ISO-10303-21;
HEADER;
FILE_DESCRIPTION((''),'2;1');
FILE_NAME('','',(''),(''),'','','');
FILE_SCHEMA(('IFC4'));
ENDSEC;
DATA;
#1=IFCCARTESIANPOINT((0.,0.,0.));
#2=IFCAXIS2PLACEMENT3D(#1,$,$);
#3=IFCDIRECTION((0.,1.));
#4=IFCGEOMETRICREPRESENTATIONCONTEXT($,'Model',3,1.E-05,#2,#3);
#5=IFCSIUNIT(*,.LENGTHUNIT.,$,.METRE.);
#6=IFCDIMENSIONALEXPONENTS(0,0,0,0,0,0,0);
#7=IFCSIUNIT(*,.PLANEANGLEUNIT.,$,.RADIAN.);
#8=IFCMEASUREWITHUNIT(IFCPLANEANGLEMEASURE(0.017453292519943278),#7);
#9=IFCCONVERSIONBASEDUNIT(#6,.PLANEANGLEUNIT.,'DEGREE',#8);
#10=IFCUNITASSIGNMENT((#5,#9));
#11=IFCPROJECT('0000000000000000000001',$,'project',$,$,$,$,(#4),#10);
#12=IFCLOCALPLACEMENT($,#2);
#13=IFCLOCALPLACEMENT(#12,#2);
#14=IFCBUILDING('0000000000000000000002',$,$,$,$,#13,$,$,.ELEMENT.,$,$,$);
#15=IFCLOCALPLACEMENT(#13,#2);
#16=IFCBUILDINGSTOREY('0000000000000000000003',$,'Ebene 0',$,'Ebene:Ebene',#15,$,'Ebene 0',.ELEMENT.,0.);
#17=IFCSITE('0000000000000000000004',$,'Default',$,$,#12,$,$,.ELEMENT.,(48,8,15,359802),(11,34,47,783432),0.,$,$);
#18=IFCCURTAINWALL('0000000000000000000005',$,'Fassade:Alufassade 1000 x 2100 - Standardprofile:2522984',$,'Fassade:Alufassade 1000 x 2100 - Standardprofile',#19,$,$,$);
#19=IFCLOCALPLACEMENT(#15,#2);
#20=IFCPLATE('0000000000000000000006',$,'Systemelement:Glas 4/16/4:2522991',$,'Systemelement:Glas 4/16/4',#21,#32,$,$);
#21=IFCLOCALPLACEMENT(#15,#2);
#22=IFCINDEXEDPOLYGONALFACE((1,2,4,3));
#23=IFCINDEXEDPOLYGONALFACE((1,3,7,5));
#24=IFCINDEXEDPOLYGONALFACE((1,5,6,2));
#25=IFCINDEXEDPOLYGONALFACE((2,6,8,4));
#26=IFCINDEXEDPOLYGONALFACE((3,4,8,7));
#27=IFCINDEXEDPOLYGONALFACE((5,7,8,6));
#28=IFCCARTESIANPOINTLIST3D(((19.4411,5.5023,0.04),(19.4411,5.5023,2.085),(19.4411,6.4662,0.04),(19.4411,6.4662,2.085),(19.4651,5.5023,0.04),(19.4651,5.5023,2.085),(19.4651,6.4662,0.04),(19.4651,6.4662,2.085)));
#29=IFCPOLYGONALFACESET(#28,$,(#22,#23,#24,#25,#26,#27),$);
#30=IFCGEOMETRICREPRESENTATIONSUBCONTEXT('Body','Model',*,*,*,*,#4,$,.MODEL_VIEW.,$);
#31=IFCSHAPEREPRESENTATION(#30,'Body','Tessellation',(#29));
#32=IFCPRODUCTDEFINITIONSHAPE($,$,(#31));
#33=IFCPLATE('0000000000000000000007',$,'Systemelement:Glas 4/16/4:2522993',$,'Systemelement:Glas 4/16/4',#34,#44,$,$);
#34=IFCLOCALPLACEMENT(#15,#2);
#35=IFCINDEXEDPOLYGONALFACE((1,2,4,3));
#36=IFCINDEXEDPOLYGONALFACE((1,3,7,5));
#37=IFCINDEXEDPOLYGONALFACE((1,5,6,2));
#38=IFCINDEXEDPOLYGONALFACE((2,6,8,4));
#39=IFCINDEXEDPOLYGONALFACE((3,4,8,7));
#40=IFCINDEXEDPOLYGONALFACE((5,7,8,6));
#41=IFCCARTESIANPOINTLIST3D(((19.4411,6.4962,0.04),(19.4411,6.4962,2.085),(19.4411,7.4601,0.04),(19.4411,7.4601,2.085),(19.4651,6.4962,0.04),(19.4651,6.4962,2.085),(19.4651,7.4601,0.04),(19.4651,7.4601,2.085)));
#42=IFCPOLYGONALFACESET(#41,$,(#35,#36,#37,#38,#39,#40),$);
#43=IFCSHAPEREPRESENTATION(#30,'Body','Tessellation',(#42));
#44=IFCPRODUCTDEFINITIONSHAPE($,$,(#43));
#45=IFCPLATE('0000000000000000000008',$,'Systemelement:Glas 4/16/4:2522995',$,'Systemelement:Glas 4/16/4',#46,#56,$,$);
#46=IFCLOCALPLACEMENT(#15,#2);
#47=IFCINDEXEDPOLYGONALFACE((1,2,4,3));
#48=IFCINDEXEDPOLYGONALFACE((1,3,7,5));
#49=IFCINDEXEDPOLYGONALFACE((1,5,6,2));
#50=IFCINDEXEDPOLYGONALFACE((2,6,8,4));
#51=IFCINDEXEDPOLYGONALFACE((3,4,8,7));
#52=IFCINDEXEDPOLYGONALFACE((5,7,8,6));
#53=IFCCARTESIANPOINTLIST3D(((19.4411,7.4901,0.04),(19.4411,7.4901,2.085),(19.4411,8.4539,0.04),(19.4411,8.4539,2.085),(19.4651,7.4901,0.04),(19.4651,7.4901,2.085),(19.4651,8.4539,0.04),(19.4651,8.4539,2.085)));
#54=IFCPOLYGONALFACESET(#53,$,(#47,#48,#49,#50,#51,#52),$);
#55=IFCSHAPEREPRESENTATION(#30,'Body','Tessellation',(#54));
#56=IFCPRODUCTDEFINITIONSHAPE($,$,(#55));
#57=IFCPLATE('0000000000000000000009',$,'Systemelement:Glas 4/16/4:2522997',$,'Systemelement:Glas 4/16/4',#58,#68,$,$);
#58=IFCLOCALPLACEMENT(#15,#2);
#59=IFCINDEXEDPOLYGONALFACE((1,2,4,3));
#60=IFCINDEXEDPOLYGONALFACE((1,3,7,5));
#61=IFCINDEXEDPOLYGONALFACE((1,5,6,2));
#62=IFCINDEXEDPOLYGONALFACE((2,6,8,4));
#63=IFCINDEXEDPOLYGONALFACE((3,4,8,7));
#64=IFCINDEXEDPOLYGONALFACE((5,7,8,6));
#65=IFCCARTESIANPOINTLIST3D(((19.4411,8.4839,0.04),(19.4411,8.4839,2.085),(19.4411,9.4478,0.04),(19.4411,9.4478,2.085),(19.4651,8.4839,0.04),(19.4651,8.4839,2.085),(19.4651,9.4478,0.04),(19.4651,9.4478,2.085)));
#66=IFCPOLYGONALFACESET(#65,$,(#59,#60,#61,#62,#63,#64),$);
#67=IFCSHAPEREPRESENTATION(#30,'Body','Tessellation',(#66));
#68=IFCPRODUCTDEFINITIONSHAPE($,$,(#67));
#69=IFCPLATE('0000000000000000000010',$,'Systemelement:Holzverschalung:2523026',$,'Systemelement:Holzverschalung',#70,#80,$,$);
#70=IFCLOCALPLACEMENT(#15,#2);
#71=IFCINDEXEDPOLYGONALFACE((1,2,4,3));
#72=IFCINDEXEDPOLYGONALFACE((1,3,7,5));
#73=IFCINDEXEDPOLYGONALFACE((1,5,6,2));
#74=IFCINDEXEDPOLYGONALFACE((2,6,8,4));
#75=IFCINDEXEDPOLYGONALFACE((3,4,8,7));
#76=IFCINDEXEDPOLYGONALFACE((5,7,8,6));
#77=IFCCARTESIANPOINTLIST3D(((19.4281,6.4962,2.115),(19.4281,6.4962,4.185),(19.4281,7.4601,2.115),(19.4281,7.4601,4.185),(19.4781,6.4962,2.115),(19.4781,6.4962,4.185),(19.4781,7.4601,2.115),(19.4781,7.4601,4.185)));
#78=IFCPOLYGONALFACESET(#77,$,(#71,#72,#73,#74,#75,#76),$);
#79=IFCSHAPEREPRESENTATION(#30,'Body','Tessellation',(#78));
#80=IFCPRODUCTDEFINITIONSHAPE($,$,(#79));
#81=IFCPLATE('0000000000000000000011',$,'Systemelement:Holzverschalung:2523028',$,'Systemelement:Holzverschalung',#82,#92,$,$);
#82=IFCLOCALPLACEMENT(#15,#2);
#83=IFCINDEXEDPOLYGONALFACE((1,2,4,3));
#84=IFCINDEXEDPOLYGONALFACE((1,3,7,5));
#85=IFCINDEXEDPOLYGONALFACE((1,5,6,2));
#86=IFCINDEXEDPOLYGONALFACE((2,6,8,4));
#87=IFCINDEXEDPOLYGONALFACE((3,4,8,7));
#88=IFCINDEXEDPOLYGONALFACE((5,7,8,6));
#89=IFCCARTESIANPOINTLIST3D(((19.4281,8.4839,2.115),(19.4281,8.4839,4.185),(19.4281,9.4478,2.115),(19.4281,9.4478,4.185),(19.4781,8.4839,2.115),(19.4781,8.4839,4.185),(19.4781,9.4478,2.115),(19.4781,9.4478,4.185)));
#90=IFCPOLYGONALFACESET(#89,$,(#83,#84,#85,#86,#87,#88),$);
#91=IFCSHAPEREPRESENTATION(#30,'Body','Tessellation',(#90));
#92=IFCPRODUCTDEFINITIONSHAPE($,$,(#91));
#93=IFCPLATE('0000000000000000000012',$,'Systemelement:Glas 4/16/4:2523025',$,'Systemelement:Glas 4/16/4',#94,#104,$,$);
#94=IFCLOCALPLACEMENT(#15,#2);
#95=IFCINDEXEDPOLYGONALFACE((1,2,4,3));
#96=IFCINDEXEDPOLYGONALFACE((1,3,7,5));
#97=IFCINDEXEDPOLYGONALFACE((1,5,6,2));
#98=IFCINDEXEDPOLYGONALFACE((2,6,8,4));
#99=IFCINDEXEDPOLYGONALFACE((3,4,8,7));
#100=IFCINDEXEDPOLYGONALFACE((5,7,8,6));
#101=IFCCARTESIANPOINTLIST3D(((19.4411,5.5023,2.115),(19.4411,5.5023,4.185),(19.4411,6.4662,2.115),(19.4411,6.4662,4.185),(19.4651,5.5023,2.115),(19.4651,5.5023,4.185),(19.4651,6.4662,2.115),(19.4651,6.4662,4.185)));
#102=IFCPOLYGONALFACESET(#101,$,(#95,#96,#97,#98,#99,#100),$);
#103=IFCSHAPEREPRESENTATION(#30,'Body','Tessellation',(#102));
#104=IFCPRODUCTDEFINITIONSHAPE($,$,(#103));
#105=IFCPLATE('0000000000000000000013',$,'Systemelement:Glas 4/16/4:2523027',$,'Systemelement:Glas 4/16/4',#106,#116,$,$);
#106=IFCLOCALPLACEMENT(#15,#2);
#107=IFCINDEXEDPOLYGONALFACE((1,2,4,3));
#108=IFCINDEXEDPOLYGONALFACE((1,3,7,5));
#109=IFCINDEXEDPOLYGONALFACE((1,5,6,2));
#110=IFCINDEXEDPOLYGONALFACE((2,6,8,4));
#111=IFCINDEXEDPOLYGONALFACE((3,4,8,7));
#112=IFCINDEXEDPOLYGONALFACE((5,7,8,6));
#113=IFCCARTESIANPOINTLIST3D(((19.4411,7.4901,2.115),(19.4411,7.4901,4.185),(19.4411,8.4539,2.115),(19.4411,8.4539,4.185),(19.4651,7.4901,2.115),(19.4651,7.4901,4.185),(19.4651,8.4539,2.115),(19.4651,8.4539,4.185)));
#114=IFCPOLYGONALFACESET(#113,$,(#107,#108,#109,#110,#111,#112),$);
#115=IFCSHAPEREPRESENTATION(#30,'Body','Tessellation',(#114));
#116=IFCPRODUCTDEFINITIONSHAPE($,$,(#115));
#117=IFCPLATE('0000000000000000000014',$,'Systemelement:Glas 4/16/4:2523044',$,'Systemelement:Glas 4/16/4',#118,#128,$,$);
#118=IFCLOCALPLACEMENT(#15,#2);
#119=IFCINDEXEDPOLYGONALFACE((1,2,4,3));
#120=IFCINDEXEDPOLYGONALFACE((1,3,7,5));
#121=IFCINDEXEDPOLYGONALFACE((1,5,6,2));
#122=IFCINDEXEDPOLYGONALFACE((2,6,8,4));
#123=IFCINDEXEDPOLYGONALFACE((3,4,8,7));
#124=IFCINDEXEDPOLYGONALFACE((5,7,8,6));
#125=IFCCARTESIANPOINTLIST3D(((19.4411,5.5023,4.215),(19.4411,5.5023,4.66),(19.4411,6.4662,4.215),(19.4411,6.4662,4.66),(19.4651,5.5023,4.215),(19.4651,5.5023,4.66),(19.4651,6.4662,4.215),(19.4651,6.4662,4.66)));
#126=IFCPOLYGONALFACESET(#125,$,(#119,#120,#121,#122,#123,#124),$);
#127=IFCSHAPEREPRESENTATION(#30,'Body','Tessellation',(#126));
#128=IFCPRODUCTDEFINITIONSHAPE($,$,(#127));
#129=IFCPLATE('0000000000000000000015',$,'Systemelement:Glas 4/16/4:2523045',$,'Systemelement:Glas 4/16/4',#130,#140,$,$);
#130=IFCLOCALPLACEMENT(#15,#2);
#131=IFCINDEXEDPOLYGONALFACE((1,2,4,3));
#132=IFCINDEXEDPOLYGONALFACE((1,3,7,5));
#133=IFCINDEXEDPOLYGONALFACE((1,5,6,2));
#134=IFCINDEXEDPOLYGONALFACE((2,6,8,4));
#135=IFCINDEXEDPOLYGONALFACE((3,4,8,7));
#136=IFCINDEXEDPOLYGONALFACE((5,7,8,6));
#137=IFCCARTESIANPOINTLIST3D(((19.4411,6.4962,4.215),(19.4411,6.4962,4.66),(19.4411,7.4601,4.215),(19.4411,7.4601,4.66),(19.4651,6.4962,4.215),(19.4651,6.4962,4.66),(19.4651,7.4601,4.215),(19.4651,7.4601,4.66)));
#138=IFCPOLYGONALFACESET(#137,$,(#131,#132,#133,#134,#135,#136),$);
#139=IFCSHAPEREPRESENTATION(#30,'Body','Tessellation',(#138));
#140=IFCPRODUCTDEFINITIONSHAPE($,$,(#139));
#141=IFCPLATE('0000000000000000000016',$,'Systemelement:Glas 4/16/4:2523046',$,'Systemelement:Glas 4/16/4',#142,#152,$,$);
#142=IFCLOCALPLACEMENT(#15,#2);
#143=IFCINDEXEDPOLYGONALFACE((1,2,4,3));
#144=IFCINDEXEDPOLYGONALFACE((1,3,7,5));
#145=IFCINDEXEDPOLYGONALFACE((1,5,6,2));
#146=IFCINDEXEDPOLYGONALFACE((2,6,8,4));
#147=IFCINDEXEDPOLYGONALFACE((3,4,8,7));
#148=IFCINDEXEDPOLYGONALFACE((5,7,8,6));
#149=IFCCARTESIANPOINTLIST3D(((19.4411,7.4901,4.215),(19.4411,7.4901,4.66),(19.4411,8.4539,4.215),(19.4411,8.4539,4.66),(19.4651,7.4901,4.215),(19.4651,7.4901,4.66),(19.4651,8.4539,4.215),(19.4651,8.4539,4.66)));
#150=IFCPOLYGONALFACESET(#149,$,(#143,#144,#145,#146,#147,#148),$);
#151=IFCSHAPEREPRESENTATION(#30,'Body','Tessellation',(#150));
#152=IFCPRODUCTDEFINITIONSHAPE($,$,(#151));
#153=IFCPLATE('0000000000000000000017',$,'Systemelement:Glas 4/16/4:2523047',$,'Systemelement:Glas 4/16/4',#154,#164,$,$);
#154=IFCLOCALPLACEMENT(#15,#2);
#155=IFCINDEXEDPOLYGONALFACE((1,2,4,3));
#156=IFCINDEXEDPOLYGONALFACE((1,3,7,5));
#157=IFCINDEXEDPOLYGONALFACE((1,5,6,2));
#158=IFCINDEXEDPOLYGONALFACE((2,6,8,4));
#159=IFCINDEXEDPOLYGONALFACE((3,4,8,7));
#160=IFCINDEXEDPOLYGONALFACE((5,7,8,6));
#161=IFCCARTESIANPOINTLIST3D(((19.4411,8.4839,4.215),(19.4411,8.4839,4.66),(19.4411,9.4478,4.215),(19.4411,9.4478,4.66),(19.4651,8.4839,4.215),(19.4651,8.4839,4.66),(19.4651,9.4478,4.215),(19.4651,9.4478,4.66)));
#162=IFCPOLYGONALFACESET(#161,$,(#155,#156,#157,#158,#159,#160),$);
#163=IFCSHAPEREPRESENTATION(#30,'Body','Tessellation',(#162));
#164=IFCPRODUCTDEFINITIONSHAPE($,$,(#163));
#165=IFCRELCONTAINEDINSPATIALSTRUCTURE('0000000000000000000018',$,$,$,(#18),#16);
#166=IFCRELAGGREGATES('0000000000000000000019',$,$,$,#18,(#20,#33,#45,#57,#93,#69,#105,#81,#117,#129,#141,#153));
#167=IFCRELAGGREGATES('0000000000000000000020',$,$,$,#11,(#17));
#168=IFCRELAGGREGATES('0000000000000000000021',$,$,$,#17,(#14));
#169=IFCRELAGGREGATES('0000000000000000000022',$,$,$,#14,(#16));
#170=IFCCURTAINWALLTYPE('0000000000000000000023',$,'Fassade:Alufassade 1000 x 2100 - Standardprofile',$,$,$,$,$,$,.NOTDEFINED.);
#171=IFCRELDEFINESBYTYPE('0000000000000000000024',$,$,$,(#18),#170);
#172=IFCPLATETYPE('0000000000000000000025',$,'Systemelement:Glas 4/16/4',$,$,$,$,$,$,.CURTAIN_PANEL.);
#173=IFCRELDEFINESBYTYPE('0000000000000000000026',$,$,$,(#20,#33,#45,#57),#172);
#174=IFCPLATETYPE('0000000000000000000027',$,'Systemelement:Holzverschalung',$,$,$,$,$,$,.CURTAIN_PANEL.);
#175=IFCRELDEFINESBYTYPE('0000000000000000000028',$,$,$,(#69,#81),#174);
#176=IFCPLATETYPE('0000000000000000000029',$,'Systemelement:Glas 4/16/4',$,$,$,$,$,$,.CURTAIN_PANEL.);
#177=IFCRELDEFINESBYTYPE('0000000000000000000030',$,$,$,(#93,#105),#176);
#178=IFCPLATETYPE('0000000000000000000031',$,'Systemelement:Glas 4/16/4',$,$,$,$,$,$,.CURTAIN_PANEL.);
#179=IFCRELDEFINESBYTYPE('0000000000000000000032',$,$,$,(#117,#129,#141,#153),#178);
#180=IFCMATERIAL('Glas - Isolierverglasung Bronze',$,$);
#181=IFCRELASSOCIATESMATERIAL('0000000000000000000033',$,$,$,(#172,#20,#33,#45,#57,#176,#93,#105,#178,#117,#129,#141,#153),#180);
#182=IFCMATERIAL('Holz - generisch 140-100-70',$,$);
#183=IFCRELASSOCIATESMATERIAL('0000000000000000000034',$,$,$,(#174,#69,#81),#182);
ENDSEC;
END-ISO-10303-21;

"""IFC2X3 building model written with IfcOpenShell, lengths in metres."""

from ifc_helpers import new_model, entity, si_unit, converted_unit, direction, frame, origin, origin_2d_with_axis, place, context, subcontext, project, spatial, rectangle, extrude, source, transform, mapped, material, type_object, type_shapes, element, aggregate, save


model = new_model("IFC2X3")

# Units and contexts
model_context = context("Model", 3, precision=1e-05, world=origin(), true_north=direction((0.0, 1.0)))
body_context = subcontext(model_context, "Body", "Model", "MODEL_VIEW")
ifc_project = project(units=[si_unit("LENGTHUNIT", "METRE"), converted_unit("PLANEANGLEUNIT", "DEGREE", entity("IfcPlaneAngleMeasure", 0.017453292519943278), si_unit("PLANEANGLEUNIT", "RADIAN"), dimensions=[0, 0, 0, 0, 0, 0, 0])], contexts=[model_context])

# Site, building, storey
site_placement = place(None, origin())
site = spatial("IfcSite", under=ifc_project, at=site_placement, Name="Default", CompositionType="ELEMENT", RefLatitude=(48, 8, 15, 359802), RefLongitude=(11, 34, 47, 783432), RefElevation=0.0)
building_placement = place(site_placement, origin())
building = spatial("IfcBuilding", under=site, at=building_placement, CompositionType="ELEMENT")
storey_placement = place(building_placement, origin())
storey = spatial("IfcBuildingStorey", under=building, at=storey_placement, Name="Ebene 0", ObjectType="Ebene:Ebene", LongName="Ebene 0", CompositionType="ELEMENT", Elevation=0.0)

# Curtain wall, plates
curtain_wall_type = type_object("IfcCurtainWallType", Name="Fassade:Alufassade 1000 x 2100 - Standardprofile", PredefinedType="NOTDEFINED")
curtain_wall_placement = place(storey_placement, origin())
curtain_wall = element("IfcCurtainWall", 1, at=curtain_wall_placement, inside=storey, type_object=curtain_wall_type, Name="Fassade:Alufassade 1000 x 2100 - Standardprofile:2522984", ObjectType="Fassade:Alufassade 1000 x 2100 - Standardprofile")
ifc_material_1 = material(Name="Glas - Isolierverglasung Bronze")
plate_type_1 = type_object("IfcPlateType", Name="Systemelement:Glas 4/16/4", PredefinedType="CURTAIN_PANEL", material=ifc_material_1)
shared_shape_1 = source(origin(), body_context, "Body", "SweptSolid", [
    extrude(rectangle(XDim=0.024, YDim=0.9639, at=origin_2d_with_axis()), frame((0.0, 0.0, 0.0), z_axis=(0.0, 0.0, 1.0), x_axis=(0.0, 1.0, 0.0)), (0.0, 0.0, 1.0), 2.045),
])
type_shapes(plate_type_1, [shared_shape_1])
plate_1_placement = place(curtain_wall_placement, frame((19.4531, 5.9842, 0.04), z_axis=(0.0, 0.0, 1.0), x_axis=(0.0, 1.0, 0.0)))
plate_1 = element("IfcPlate", 2, at=plate_1_placement, type_object=plate_type_1, material=ifc_material_1, Name="Systemelement:Glas 4/16/4:2522991", ObjectType="Systemelement:Glas 4/16/4", context=body_context, shape_type="MappedRepresentation", body=[
    mapped(shared_shape_1, transform((0.0, 0.0, 0.0), scale=1.0)),
])
plate_2_placement = place(curtain_wall_placement, frame((19.4531, 6.9781, 0.04), z_axis=(0.0, 0.0, 1.0), x_axis=(0.0, 1.0, 0.0)))
plate_2 = element("IfcPlate", 3, at=plate_2_placement, type_object=plate_type_1, material=ifc_material_1, Name="Systemelement:Glas 4/16/4:2522993", ObjectType="Systemelement:Glas 4/16/4", context=body_context, shape_type="MappedRepresentation", body=[
    mapped(shared_shape_1, transform((0.0, 0.0, 0.0), scale=1.0)),
])
plate_3_placement = place(curtain_wall_placement, frame((19.4531, 7.972, 0.04), z_axis=(0.0, 0.0, 1.0), x_axis=(0.0, 1.0, 0.0)))
plate_3 = element("IfcPlate", 4, at=plate_3_placement, type_object=plate_type_1, material=ifc_material_1, Name="Systemelement:Glas 4/16/4:2522995", ObjectType="Systemelement:Glas 4/16/4", context=body_context, shape_type="MappedRepresentation", body=[
    mapped(shared_shape_1, transform((0.0, 0.0, 0.0), scale=1.0)),
])
plate_4_placement = place(curtain_wall_placement, frame((19.4531, 8.9659, 0.04), z_axis=(0.0, 0.0, 1.0), x_axis=(0.0, 1.0, 0.0)))
plate_4 = element("IfcPlate", 5, at=plate_4_placement, type_object=plate_type_1, material=ifc_material_1, Name="Systemelement:Glas 4/16/4:2522997", ObjectType="Systemelement:Glas 4/16/4", context=body_context, shape_type="MappedRepresentation", body=[
    mapped(shared_shape_1, transform((0.0, 0.0, 0.0), scale=1.0)),
])
ifc_material_2 = material(Name="Holz - generisch 140-100-70")
plate_type_2 = type_object("IfcPlateType", Name="Systemelement:Holzverschalung", PredefinedType="CURTAIN_PANEL", material=ifc_material_2)
shared_shape_2 = source(origin(), body_context, "Body", "SweptSolid", [
    extrude(rectangle(XDim=0.05, YDim=0.9639, at=origin_2d_with_axis()), frame((0.0, 0.0, 0.0), z_axis=(0.0, 0.0, 1.0), x_axis=(0.0, 1.0, 0.0)), (0.0, 0.0, 1.0), 2.07),
])
type_shapes(plate_type_2, [shared_shape_2])
plate_5_placement = place(curtain_wall_placement, frame((19.4531, 6.9781, 2.115), z_axis=(0.0, 0.0, 1.0), x_axis=(0.0, 1.0, 0.0)))
plate_5 = element("IfcPlate", 6, at=plate_5_placement, type_object=plate_type_2, material=ifc_material_2, Name="Systemelement:Holzverschalung:2523026", ObjectType="Systemelement:Holzverschalung", context=body_context, shape_type="MappedRepresentation", body=[
    mapped(shared_shape_2, transform((0.0, 0.0, 0.0), scale=1.0)),
])
plate_6_placement = place(curtain_wall_placement, frame((19.4531, 8.9659, 2.115), z_axis=(0.0, 0.0, 1.0), x_axis=(0.0, 1.0, 0.0)))
plate_6 = element("IfcPlate", 7, at=plate_6_placement, type_object=plate_type_2, material=ifc_material_2, Name="Systemelement:Holzverschalung:2523028", ObjectType="Systemelement:Holzverschalung", context=body_context, shape_type="MappedRepresentation", body=[
    mapped(shared_shape_2, transform((0.0, 0.0, 0.0), scale=1.0)),
])
plate_type_3 = type_object("IfcPlateType", Name="Systemelement:Glas 4/16/4", PredefinedType="CURTAIN_PANEL", material=ifc_material_1)
shared_shape_3 = source(origin(), body_context, "Body", "SweptSolid", [
    extrude(rectangle(XDim=0.024, YDim=0.9639, at=origin_2d_with_axis()), frame((0.0, 0.0, 0.0), z_axis=(0.0, 0.0, 1.0), x_axis=(0.0, 1.0, 0.0)), (0.0, 0.0, 1.0), 2.07),
])
type_shapes(plate_type_3, [shared_shape_3])
plate_7_placement = place(curtain_wall_placement, frame((19.4531, 5.9842, 2.115), z_axis=(0.0, 0.0, 1.0), x_axis=(0.0, 1.0, 0.0)))
plate_7 = element("IfcPlate", 8, at=plate_7_placement, type_object=plate_type_3, material=ifc_material_1, Name="Systemelement:Glas 4/16/4:2523025", ObjectType="Systemelement:Glas 4/16/4", context=body_context, shape_type="MappedRepresentation", body=[
    mapped(shared_shape_3, transform((0.0, 0.0, 0.0), scale=1.0)),
])
plate_8_placement = place(curtain_wall_placement, frame((19.4531, 7.972, 2.115), z_axis=(0.0, 0.0, 1.0), x_axis=(0.0, 1.0, 0.0)))
plate_8 = element("IfcPlate", 9, at=plate_8_placement, type_object=plate_type_3, material=ifc_material_1, Name="Systemelement:Glas 4/16/4:2523027", ObjectType="Systemelement:Glas 4/16/4", context=body_context, shape_type="MappedRepresentation", body=[
    mapped(shared_shape_3, transform((0.0, 0.0, 0.0), scale=1.0)),
])
plate_type_4 = type_object("IfcPlateType", Name="Systemelement:Glas 4/16/4", PredefinedType="CURTAIN_PANEL", material=ifc_material_1)
shared_shape_4 = source(origin(), body_context, "Body", "SweptSolid", [
    extrude(rectangle(XDim=0.024, YDim=0.9639, at=origin_2d_with_axis()), frame((0.0, 0.0, 0.0), z_axis=(0.0, 0.0, 1.0), x_axis=(0.0, 1.0, 0.0)), (0.0, 0.0, 1.0), 0.445),
])
type_shapes(plate_type_4, [shared_shape_4])
plate_9_placement = place(curtain_wall_placement, frame((19.4531, 5.9842, 4.215), z_axis=(0.0, 0.0, 1.0), x_axis=(0.0, 1.0, 0.0)))
plate_9 = element("IfcPlate", 10, at=plate_9_placement, type_object=plate_type_4, material=ifc_material_1, Name="Systemelement:Glas 4/16/4:2523044", ObjectType="Systemelement:Glas 4/16/4", context=body_context, shape_type="MappedRepresentation", body=[
    mapped(shared_shape_4, transform((0.0, 0.0, 0.0), scale=1.0)),
])
plate_10_placement = place(curtain_wall_placement, frame((19.4531, 6.9781, 4.215), z_axis=(0.0, 0.0, 1.0), x_axis=(0.0, 1.0, 0.0)))
plate_10 = element("IfcPlate", 11, at=plate_10_placement, type_object=plate_type_4, material=ifc_material_1, Name="Systemelement:Glas 4/16/4:2523045", ObjectType="Systemelement:Glas 4/16/4", context=body_context, shape_type="MappedRepresentation", body=[
    mapped(shared_shape_4, transform((0.0, 0.0, 0.0), scale=1.0)),
])
plate_11_placement = place(curtain_wall_placement, frame((19.4531, 7.972, 4.215), z_axis=(0.0, 0.0, 1.0), x_axis=(0.0, 1.0, 0.0)))
plate_11 = element("IfcPlate", 12, at=plate_11_placement, type_object=plate_type_4, material=ifc_material_1, Name="Systemelement:Glas 4/16/4:2523046", ObjectType="Systemelement:Glas 4/16/4", context=body_context, shape_type="MappedRepresentation", body=[
    mapped(shared_shape_4, transform((0.0, 0.0, 0.0), scale=1.0)),
])
plate_12_placement = place(curtain_wall_placement, frame((19.4531, 8.9659, 4.215), z_axis=(0.0, 0.0, 1.0), x_axis=(0.0, 1.0, 0.0)))
plate_12 = element("IfcPlate", 13, at=plate_12_placement, type_object=plate_type_4, material=ifc_material_1, Name="Systemelement:Glas 4/16/4:2523047", ObjectType="Systemelement:Glas 4/16/4", context=body_context, shape_type="MappedRepresentation", body=[
    mapped(shared_shape_4, transform((0.0, 0.0, 0.0), scale=1.0)),
])
aggregate(curtain_wall, [plate_1, plate_2, plate_3, plate_4, plate_7, plate_5, plate_8, plate_6, plate_9, plate_10, plate_11, plate_12])

save(model, "model.ifc")
